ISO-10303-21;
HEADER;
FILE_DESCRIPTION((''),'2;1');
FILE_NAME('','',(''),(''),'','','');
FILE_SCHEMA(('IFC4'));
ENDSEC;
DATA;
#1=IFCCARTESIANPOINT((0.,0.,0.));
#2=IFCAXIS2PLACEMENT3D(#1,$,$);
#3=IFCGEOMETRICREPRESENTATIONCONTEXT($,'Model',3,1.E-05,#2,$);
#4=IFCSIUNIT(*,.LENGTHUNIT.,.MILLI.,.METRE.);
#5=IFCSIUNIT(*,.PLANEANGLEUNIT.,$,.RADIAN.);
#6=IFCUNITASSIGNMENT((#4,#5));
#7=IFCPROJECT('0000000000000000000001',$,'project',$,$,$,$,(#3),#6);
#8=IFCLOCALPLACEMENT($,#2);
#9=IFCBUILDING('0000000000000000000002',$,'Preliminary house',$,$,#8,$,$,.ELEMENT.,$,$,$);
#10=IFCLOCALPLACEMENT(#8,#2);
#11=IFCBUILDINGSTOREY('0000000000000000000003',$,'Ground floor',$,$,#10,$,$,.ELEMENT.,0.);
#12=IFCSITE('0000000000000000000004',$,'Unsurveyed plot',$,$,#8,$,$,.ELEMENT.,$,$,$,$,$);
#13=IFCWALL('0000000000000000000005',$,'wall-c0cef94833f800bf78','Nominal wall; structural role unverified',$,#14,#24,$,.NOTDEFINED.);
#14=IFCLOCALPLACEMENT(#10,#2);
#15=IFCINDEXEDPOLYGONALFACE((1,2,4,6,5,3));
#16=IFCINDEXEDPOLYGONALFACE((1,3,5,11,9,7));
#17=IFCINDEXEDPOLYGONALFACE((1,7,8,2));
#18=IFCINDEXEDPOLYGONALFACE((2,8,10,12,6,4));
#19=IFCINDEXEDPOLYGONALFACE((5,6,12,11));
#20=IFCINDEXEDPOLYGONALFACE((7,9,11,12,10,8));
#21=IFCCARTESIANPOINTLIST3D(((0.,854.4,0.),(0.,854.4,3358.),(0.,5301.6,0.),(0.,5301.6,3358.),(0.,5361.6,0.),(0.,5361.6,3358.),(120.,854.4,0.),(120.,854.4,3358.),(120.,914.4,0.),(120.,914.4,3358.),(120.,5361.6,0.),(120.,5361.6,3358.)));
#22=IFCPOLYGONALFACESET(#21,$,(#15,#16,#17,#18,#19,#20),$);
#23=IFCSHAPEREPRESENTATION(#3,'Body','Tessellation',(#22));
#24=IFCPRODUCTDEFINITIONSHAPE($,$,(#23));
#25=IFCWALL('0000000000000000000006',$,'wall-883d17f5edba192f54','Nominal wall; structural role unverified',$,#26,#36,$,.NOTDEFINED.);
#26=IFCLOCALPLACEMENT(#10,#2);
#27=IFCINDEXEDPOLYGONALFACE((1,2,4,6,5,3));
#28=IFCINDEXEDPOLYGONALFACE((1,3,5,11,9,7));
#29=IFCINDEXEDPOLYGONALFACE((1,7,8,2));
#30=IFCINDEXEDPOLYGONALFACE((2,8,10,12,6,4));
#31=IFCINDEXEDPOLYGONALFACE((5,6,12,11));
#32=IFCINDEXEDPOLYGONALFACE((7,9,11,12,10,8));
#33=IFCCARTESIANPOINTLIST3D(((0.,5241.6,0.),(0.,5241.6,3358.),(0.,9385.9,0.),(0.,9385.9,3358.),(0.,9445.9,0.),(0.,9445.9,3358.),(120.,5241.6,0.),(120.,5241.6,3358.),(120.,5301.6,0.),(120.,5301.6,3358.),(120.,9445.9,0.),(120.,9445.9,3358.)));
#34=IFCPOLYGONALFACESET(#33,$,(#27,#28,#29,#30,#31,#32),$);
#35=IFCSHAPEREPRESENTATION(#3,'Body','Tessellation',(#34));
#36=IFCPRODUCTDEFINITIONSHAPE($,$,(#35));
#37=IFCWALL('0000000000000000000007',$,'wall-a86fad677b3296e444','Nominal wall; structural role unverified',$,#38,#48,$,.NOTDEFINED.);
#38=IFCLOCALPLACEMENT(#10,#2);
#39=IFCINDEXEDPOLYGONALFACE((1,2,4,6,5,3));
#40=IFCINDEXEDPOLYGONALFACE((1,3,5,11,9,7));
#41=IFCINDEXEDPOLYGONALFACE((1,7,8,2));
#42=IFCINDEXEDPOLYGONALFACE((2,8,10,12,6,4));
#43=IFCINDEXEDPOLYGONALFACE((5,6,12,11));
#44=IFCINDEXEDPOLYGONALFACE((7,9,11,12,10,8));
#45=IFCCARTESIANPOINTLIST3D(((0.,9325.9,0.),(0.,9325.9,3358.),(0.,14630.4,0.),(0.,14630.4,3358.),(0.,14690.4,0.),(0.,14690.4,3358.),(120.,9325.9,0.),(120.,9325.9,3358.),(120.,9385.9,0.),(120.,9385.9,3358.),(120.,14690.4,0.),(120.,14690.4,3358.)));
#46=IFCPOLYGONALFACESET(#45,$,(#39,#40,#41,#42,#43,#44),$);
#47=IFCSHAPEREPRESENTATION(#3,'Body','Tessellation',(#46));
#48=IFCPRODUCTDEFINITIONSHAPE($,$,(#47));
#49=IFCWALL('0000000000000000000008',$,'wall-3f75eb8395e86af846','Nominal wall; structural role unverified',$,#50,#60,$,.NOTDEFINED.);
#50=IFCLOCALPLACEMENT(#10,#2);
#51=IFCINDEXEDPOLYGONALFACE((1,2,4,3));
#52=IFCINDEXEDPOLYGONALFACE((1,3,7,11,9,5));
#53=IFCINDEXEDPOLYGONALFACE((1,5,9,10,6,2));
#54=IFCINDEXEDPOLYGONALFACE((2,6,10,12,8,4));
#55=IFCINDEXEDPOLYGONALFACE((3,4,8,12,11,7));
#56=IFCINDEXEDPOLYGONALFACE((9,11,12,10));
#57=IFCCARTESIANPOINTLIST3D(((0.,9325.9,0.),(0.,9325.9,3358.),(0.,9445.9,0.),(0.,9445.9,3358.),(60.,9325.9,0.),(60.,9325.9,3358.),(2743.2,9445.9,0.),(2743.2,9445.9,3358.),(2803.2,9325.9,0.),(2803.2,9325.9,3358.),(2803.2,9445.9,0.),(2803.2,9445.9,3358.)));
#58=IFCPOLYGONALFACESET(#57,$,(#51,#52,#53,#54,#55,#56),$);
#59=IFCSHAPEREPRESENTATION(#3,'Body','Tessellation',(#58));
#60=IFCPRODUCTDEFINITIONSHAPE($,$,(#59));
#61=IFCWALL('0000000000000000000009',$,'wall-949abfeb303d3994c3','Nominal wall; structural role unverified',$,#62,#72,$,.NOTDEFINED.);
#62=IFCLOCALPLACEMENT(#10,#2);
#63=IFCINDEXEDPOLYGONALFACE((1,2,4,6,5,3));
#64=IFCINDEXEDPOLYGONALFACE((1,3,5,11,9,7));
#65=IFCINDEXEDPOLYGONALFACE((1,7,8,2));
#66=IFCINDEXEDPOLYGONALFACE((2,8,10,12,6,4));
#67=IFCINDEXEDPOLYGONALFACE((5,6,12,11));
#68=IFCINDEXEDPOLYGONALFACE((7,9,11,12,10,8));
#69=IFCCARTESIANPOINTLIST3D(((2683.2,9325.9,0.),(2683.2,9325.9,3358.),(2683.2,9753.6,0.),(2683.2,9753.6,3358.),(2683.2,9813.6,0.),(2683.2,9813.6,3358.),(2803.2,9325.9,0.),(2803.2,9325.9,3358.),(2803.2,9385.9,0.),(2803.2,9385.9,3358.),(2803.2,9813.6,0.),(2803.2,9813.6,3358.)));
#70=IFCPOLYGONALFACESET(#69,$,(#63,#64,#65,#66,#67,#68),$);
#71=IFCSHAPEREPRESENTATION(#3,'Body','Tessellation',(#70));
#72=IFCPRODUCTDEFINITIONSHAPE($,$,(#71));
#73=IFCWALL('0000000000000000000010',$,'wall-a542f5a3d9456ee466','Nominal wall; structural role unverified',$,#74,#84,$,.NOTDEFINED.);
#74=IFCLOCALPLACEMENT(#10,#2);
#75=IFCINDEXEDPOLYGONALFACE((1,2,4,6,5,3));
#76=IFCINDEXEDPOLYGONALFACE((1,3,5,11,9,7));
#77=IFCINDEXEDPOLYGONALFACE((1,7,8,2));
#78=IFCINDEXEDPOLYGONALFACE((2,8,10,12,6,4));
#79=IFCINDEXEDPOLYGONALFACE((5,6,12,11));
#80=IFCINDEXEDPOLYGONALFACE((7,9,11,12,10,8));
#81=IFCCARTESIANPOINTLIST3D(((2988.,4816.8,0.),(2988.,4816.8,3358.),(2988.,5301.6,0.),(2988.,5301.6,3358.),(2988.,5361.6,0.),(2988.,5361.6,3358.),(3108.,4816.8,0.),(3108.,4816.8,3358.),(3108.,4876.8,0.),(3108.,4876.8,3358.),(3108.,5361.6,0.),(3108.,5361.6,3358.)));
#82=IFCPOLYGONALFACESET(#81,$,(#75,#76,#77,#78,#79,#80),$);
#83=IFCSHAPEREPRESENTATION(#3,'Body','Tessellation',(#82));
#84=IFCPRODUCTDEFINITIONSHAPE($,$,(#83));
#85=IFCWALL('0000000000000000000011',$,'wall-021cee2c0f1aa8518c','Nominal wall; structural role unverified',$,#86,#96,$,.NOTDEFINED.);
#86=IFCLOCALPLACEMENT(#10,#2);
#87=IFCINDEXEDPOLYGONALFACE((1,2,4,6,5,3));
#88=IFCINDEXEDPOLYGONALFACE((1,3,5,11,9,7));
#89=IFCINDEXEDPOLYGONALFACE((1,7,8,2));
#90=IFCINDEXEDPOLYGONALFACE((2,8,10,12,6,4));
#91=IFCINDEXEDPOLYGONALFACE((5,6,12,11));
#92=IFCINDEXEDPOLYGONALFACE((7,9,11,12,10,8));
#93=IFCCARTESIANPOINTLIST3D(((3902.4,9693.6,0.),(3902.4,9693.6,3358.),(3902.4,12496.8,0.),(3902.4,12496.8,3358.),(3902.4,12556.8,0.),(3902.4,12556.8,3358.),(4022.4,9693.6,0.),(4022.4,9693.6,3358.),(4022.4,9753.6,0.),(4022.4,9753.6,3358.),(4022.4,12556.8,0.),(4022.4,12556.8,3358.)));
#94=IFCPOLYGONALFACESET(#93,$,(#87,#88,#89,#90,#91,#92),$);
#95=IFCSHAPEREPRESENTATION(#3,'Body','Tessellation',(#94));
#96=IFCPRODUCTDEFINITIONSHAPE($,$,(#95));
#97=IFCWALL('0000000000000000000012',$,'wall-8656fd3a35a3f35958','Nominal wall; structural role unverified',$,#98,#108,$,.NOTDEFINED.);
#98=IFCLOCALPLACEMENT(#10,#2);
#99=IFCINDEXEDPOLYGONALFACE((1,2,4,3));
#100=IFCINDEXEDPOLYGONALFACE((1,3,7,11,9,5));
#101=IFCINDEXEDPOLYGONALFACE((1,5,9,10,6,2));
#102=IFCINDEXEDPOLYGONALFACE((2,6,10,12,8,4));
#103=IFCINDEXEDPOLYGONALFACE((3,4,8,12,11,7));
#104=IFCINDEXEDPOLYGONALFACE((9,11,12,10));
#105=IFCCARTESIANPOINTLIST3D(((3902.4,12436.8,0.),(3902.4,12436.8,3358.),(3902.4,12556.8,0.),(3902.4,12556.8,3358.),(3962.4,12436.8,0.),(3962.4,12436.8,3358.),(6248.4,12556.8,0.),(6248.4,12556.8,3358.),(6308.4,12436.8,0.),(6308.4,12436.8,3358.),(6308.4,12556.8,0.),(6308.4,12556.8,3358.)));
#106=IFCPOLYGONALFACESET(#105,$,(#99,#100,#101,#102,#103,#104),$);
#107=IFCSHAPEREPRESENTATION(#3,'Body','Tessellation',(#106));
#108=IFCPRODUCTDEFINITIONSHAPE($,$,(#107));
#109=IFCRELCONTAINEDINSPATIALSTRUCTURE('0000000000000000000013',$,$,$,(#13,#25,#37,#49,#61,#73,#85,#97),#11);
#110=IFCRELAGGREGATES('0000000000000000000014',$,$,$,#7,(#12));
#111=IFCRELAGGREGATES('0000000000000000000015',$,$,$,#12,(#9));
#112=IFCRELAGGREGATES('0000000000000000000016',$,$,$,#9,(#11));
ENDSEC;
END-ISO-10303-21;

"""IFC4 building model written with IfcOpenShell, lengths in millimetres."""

from ifc_helpers import new_model, si_unit, origin, place, context, project, spatial, polyline, outline, extrude, element, save


model = new_model("IFC4")

# Units and contexts
model_context = context("Model", 3, precision=1e-05, world=origin())
ifc_project = project(units=[si_unit("LENGTHUNIT", "METRE", prefix="MILLI"), si_unit("PLANEANGLEUNIT", "RADIAN")], contexts=[model_context])

# Site, building, storey
placement_1 = place(None, origin())
site = spatial("IfcSite", under=ifc_project, at=placement_1, Name="Unsurveyed plot", CompositionType="ELEMENT")
building = spatial("IfcBuilding", under=site, at=placement_1, Name="Preliminary house", CompositionType="ELEMENT")
placement_2 = place(placement_1, origin())
storey = spatial("IfcBuildingStorey", under=building, at=placement_2, Name="Ground floor", CompositionType="ELEMENT", Elevation=0.0)

# Wall
element("IfcWall", 1, at=placement_2, inside=storey, Name="wall-c0cef94833f800bf78", Description="Nominal wall; structural role unverified", PredefinedType="NOTDEFINED", context=model_context, shape_type="SweptSolid", body=[
    extrude(outline(polyline([(0.0, 5301.6), (0.0, 5361.6), (120.0, 5361.6), (120.0, 914.4), (120.0, 854.4), (0.0, 854.4), (0.0, 5301.6)])), origin(), (0.0, 0.0, 1.0), 3358.0),
])

# Wall
element("IfcWall", 2, at=placement_2, inside=storey, Name="wall-883d17f5edba192f54", Description="Nominal wall; structural role unverified", PredefinedType="NOTDEFINED", context=model_context, shape_type="SweptSolid", body=[
    extrude(outline(polyline([(0.0, 9385.9), (0.0, 9445.9), (120.0, 9445.9), (120.0, 5301.6), (120.0, 5241.6), (0.0, 5241.6), (0.0, 9385.9)])), origin(), (0.0, 0.0, 1.0), 3358.0),
])

# Walls
element("IfcWall", 3, at=placement_2, inside=storey, Name="wall-a86fad677b3296e444", Description="Nominal wall; structural role unverified", PredefinedType="NOTDEFINED", context=model_context, shape_type="SweptSolid", body=[
    extrude(outline(polyline([(0.0, 14630.4), (0.0, 14690.4), (120.0, 14690.4), (120.0, 9385.9), (120.0, 9325.9), (0.0, 9325.9), (0.0, 14630.4)])), origin(), (0.0, 0.0, 1.0), 3358.0),
])
element("IfcWall", 4, at=placement_2, inside=storey, Name="wall-3f75eb8395e86af846", Description="Nominal wall; structural role unverified", PredefinedType="NOTDEFINED", context=model_context, shape_type="SweptSolid", body=[
    extrude(outline(polyline([(2743.2, 9445.9), (2803.2, 9445.9), (2803.2, 9325.9), (60.0, 9325.9), (0.0, 9325.9), (0.0, 9445.9), (2743.2, 9445.9)])), origin(), (0.0, 0.0, 1.0), 3358.0),
])

# Wall
element("IfcWall", 5, at=placement_2, inside=storey, Name="wall-949abfeb303d3994c3", Description="Nominal wall; structural role unverified", PredefinedType="NOTDEFINED", context=model_context, shape_type="SweptSolid", body=[
    extrude(outline(polyline([(2683.2, 9753.6), (2683.2, 9813.6), (2803.2, 9813.6), (2803.2, 9385.9), (2803.2, 9325.9), (2683.2, 9325.9), (2683.2, 9753.6)])), origin(), (0.0, 0.0, 1.0), 3358.0),
])

# Wall
element("IfcWall", 6, at=placement_2, inside=storey, Name="wall-a542f5a3d9456ee466", Description="Nominal wall; structural role unverified", PredefinedType="NOTDEFINED", context=model_context, shape_type="SweptSolid", body=[
    extrude(outline(polyline([(2988.0, 5301.6), (2988.0, 5361.6), (3108.0, 5361.6), (3108.0, 4876.8), (3108.0, 4816.8), (2988.0, 4816.8), (2988.0, 5301.6)])), origin(), (0.0, 0.0, 1.0), 3358.0),
])

# Wall
element("IfcWall", 7, at=placement_2, inside=storey, Name="wall-021cee2c0f1aa8518c", Description="Nominal wall; structural role unverified", PredefinedType="NOTDEFINED", context=model_context, shape_type="SweptSolid", body=[
    extrude(outline(polyline([(3902.4, 12496.8), (3902.4, 12556.8), (4022.4, 12556.8), (4022.4, 9753.6), (4022.4, 9693.6), (3902.4, 9693.6), (3902.4, 12496.8)])), origin(), (0.0, 0.0, 1.0), 3358.0),
])

# Wall
element("IfcWall", 8, at=placement_2, inside=storey, Name="wall-8656fd3a35a3f35958", Description="Nominal wall; structural role unverified", PredefinedType="NOTDEFINED", context=model_context, shape_type="SweptSolid", body=[
    extrude(outline(polyline([(6248.4, 12556.8), (6308.4, 12556.8), (6308.4, 12436.8), (3962.4, 12436.8), (3902.4, 12436.8), (3902.4, 12556.8), (6248.4, 12556.8)])), origin(), (0.0, 0.0, 1.0), 3358.0),
])

save(model, "model.ifc")
